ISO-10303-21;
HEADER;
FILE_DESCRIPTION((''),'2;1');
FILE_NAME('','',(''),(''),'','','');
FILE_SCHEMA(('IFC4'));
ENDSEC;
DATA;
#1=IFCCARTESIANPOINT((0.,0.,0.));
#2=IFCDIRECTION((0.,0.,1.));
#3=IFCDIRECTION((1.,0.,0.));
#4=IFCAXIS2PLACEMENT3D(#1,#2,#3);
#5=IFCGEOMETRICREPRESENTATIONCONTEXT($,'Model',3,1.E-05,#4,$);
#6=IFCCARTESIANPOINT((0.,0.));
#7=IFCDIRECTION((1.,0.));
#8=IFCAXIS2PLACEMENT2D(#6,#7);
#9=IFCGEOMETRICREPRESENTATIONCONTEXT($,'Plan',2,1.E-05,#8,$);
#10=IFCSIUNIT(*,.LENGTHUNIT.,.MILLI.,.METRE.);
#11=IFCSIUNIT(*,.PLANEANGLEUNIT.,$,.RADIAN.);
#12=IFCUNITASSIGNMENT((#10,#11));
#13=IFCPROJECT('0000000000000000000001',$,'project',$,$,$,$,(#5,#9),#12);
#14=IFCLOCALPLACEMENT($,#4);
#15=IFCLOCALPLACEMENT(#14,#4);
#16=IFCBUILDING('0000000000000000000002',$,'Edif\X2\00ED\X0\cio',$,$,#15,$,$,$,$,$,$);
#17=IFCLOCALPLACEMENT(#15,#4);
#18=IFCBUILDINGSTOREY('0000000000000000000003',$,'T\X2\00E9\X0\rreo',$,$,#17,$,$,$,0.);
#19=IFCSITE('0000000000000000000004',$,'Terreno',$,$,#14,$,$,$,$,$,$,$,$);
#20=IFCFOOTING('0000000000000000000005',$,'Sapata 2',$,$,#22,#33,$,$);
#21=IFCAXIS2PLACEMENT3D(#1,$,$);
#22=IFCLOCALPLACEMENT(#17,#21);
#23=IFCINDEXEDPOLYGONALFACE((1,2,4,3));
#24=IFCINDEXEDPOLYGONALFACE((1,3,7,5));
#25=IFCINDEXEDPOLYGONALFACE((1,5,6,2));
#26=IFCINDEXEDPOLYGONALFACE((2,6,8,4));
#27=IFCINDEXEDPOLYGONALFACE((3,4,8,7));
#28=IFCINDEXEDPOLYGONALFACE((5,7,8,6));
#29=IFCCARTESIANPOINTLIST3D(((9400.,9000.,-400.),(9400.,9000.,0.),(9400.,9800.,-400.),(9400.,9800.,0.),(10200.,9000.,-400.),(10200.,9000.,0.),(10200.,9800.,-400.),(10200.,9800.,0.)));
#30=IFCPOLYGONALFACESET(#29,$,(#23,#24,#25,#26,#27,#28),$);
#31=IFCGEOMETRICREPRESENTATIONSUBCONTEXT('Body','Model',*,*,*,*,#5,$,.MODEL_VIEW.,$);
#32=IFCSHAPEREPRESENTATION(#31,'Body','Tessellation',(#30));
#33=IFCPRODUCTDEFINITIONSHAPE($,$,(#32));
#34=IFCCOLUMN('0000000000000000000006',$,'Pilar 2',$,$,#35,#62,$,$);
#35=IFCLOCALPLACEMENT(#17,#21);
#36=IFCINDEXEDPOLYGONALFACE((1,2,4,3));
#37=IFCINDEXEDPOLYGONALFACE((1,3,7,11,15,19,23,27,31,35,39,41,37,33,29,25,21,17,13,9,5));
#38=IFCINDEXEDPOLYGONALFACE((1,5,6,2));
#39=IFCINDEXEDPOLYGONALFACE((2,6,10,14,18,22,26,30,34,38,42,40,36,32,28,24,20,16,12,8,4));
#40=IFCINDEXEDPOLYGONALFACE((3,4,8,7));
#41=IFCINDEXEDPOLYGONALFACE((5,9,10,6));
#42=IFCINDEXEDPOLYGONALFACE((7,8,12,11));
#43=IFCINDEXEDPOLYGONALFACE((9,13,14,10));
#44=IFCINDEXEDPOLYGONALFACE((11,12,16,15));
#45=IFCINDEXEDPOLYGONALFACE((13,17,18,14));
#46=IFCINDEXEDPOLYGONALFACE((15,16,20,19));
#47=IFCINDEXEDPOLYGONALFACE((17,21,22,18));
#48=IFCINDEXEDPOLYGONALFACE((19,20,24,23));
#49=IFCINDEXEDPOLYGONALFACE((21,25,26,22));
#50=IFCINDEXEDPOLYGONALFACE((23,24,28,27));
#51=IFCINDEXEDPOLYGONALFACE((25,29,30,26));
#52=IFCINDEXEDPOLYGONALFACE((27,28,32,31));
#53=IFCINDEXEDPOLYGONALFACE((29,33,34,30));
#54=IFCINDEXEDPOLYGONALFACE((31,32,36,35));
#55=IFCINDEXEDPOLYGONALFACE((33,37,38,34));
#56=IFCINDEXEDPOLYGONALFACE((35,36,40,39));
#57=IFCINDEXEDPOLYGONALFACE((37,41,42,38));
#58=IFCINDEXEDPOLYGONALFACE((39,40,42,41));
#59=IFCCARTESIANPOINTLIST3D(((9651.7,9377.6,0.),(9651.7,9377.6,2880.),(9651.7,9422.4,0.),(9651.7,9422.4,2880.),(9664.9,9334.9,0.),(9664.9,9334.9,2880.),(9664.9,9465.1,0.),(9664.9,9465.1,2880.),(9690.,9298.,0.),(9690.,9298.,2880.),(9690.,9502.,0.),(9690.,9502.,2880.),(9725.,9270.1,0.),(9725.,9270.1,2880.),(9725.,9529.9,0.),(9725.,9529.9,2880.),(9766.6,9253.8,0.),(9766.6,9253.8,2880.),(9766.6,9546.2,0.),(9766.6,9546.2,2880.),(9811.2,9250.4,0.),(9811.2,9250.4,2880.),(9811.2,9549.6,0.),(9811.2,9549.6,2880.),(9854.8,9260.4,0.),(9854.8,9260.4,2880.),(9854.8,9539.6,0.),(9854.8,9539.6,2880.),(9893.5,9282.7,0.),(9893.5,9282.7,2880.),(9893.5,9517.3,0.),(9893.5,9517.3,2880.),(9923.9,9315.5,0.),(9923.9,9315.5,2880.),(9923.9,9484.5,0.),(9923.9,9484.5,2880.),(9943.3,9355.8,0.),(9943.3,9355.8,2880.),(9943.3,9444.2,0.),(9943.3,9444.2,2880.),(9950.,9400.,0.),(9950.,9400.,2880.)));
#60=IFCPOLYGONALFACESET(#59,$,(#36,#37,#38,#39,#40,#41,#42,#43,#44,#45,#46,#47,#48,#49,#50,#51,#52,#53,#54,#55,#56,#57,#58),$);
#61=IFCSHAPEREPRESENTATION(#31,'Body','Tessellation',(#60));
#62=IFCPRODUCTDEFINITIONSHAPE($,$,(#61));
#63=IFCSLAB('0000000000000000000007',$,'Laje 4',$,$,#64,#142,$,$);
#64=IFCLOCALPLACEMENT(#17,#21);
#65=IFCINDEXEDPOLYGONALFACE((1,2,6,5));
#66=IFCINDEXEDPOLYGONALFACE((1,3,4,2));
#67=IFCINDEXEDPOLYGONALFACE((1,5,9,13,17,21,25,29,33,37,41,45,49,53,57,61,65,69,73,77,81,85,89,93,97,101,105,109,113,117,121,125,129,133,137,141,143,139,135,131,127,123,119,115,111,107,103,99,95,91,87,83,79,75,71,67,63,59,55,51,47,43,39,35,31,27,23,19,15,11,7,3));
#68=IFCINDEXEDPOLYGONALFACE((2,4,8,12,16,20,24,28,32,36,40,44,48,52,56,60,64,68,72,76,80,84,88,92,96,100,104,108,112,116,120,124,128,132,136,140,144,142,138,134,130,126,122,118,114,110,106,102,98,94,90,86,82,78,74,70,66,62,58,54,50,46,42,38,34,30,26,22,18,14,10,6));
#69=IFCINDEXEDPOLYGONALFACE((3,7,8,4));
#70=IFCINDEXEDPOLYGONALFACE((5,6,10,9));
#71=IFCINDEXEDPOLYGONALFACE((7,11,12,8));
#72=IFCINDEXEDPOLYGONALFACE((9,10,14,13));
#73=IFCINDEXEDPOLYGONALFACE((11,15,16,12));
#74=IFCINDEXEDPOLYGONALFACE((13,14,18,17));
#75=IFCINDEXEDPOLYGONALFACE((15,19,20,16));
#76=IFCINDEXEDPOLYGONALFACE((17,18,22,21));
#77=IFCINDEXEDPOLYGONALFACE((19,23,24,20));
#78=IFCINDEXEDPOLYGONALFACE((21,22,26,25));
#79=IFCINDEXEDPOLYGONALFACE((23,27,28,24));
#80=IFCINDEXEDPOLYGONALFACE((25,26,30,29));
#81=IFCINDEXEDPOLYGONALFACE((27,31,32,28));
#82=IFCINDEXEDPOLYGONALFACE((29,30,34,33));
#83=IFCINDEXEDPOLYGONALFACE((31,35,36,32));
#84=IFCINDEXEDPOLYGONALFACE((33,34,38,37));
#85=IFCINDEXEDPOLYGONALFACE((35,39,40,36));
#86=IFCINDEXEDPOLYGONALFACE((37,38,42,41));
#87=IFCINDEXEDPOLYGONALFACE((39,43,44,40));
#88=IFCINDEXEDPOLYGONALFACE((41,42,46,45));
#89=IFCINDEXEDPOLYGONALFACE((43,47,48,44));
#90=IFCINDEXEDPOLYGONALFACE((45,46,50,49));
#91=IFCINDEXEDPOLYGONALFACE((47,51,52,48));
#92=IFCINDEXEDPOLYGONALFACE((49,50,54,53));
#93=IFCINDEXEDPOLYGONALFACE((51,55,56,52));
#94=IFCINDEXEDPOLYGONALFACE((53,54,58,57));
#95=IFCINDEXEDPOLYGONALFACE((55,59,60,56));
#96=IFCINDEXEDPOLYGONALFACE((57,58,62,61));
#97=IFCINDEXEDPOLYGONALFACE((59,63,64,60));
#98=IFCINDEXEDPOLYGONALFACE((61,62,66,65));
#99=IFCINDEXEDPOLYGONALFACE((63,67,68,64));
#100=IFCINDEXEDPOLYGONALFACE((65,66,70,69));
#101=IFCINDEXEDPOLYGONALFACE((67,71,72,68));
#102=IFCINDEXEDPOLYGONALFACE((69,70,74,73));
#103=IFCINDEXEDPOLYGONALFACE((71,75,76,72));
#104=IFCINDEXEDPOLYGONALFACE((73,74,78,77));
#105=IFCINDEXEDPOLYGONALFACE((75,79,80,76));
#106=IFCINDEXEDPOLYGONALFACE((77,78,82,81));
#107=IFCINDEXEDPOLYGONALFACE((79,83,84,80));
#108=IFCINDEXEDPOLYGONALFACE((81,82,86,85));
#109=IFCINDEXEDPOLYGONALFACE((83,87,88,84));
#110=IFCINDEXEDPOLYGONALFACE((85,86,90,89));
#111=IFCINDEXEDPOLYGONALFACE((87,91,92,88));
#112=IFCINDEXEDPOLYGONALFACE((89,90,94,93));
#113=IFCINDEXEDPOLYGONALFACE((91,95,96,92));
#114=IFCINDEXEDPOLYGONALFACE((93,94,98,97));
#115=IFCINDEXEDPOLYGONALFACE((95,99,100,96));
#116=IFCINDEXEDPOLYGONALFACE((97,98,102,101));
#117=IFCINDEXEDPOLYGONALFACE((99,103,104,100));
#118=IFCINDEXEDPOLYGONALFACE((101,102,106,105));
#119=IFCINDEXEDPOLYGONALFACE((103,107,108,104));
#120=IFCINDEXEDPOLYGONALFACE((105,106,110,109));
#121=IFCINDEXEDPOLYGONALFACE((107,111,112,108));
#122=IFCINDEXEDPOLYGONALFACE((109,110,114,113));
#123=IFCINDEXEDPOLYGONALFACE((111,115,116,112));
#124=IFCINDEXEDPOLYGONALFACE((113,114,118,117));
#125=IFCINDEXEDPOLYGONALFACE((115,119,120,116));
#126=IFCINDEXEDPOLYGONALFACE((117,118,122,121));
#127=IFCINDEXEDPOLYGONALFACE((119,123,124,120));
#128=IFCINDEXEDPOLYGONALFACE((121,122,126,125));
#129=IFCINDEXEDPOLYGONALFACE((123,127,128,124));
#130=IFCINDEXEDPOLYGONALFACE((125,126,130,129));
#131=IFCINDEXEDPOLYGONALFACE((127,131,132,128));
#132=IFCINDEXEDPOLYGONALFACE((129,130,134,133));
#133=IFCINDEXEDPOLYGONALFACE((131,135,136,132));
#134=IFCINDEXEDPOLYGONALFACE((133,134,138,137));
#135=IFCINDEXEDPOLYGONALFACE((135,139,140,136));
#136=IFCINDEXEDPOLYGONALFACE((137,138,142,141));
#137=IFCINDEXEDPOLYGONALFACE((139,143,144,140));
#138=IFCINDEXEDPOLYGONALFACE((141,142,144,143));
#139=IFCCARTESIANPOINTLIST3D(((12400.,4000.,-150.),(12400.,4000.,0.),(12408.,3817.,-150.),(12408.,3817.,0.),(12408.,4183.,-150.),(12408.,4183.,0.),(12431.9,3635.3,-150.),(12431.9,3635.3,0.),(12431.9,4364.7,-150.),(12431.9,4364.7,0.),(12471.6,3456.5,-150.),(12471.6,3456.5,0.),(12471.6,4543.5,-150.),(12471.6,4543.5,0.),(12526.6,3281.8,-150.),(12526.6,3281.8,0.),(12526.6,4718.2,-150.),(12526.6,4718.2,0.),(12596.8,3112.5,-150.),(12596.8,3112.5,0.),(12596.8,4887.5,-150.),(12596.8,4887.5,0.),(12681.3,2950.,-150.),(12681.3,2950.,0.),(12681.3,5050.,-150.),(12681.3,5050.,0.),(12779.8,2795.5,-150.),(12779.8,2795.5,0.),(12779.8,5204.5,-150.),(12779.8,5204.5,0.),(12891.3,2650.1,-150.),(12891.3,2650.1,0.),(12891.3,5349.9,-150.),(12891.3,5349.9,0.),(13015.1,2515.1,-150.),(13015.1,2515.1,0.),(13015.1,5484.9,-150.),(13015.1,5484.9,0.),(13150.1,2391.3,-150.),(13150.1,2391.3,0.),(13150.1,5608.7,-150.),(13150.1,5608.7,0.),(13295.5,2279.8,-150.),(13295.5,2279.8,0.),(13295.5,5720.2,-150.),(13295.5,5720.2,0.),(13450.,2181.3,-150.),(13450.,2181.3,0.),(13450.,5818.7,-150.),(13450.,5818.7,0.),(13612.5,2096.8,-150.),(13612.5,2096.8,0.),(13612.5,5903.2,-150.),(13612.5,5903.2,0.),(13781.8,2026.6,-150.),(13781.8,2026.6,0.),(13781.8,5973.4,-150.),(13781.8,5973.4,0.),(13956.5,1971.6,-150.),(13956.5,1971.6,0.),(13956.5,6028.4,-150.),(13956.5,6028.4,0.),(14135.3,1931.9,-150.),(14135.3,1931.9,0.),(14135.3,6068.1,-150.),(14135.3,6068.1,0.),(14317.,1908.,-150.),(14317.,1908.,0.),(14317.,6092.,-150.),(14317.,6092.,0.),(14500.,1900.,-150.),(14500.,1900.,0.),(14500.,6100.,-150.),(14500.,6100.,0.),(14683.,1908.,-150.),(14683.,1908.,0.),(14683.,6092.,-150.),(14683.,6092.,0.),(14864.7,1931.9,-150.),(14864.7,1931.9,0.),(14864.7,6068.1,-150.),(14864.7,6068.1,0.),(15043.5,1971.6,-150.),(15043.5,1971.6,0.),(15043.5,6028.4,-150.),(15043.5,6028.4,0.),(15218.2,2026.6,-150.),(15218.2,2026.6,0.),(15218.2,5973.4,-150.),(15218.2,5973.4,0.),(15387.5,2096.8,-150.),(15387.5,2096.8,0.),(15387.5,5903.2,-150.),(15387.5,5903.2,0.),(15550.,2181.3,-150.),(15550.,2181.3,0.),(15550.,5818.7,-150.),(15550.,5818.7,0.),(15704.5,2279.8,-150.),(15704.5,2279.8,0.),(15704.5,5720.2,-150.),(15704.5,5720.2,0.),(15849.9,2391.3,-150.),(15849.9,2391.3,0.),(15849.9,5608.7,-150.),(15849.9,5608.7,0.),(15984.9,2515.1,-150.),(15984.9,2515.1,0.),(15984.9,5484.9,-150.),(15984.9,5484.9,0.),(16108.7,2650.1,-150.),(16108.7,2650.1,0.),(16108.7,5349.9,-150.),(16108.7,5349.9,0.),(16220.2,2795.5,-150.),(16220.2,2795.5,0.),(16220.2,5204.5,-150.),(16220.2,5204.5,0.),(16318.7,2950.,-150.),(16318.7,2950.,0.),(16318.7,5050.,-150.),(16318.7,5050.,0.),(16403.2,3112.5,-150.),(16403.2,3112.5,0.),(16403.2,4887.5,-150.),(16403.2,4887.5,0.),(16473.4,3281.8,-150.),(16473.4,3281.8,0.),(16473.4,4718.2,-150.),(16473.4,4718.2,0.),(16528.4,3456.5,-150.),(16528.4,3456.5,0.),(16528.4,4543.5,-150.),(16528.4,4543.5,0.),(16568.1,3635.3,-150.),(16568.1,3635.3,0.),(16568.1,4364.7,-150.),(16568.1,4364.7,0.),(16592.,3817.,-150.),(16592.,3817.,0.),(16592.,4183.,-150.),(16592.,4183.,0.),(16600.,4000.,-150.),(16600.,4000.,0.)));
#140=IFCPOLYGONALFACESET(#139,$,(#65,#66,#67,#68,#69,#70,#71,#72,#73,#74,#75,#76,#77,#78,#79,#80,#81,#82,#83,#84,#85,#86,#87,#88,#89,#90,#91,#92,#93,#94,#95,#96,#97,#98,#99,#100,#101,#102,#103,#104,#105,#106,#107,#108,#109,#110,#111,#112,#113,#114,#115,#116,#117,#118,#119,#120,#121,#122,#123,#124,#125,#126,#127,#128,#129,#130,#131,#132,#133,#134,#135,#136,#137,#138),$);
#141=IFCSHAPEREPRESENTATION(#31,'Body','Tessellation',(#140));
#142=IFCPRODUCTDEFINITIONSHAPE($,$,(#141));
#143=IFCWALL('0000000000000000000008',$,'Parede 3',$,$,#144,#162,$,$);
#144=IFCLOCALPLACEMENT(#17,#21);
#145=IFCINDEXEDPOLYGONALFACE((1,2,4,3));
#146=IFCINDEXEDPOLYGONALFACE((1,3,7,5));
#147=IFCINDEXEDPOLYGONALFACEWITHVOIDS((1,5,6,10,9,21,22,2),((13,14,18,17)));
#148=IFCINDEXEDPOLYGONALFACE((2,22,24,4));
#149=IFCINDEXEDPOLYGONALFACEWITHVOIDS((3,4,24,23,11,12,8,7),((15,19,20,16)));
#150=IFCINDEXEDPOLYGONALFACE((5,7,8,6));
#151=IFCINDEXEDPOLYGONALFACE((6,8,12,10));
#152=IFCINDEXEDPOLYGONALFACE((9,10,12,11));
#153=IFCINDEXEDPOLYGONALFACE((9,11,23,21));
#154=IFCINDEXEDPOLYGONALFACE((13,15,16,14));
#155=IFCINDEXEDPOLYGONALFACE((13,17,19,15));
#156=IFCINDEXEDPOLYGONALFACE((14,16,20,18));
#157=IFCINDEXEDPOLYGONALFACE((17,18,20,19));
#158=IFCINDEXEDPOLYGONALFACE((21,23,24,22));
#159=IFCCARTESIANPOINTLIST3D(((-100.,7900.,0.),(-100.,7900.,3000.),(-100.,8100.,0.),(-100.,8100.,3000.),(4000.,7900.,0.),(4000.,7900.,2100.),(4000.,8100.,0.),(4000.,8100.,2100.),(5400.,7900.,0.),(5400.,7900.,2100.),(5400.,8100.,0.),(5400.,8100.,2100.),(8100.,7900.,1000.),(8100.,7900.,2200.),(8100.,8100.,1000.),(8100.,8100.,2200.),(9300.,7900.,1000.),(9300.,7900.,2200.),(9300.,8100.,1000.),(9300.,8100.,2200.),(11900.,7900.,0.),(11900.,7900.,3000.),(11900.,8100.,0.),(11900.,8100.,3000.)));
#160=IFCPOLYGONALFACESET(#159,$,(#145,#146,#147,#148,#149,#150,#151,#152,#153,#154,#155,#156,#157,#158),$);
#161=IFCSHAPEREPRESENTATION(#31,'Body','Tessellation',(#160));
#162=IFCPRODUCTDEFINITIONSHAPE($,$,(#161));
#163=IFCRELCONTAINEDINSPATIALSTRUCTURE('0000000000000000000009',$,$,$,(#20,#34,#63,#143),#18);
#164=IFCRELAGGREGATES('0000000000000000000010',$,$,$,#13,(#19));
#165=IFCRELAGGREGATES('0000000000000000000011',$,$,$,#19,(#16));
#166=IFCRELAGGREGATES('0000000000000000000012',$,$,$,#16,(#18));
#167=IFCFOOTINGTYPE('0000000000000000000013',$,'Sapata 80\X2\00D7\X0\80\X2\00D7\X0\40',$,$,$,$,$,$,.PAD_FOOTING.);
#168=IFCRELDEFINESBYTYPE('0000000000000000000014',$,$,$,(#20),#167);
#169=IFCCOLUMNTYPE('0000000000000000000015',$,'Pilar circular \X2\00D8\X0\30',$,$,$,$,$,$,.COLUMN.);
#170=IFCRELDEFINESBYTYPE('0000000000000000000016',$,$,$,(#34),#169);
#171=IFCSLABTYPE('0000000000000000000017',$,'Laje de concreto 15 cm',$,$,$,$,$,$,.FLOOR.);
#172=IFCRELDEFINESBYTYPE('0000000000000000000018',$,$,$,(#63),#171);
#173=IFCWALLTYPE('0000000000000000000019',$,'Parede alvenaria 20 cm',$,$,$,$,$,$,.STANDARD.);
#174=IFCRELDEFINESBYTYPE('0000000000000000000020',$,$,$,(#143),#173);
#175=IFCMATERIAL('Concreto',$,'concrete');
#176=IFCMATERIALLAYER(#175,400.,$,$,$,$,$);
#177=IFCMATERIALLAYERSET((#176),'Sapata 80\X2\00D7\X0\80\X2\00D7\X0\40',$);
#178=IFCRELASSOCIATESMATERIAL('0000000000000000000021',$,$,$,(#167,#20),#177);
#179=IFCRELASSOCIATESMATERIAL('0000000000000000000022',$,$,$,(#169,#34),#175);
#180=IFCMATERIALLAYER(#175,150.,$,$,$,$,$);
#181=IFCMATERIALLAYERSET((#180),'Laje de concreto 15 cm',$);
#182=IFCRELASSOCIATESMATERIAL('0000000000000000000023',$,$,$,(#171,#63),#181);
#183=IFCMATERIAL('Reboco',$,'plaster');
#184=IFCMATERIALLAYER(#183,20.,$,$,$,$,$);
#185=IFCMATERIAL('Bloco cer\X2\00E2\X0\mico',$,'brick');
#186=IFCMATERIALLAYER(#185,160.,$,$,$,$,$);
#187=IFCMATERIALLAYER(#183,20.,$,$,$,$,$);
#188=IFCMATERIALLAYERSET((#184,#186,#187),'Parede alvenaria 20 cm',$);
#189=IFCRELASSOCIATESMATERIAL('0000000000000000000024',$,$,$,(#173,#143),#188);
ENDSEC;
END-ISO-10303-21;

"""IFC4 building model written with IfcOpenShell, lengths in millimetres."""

from ifc_helpers import new_model, si_unit, frame, origin_with_axes, origin_2d, origin_2d_with_axis, place, context, subcontext, project, spatial, indexed_curve, circle, outline, extrude, material, layer, layer_set, layer_usage, material_profile, profile_set, profile_usage, type_object, element, save


model = new_model("IFC4")

# Units and contexts
model_context = context("Model", 3, precision=1e-05, world=origin_with_axes())
plan_context = context("Plan", 2, precision=1e-05, world=origin_2d_with_axis())
body_context = subcontext(model_context, "Body", "Model", "MODEL_VIEW")
ifc_project = project(units=[si_unit("LENGTHUNIT", "METRE", prefix="MILLI"), si_unit("PLANEANGLEUNIT", "RADIAN")], contexts=[model_context, plan_context])

# Site, building, storey
site_placement = place(None, origin_with_axes())
site = spatial("IfcSite", under=ifc_project, at=site_placement, Name="Terreno")
building_placement = place(site_placement, origin_with_axes())
building = spatial("IfcBuilding", under=site, at=building_placement, Name="Edifício")
storey_placement = place(building_placement, origin_with_axes())
storey = spatial("IfcBuildingStorey", under=building, at=storey_placement, Name="Térreo", Elevation=0.0)

# Footing
ifc_material_1 = material(Name="Concreto", Category="concrete")
ifc_layer_1 = layer(ifc_material_1, 400.0)
ifc_layer_set_1 = layer_set([ifc_layer_1], Name="Sapata 80×80×40")
ifc_layer_usage_1 = layer_usage(ifc_layer_set_1, "AXIS3", "POSITIVE", 0.0)
footing_type = type_object("IfcFootingType", Name="Sapata 80×80×40", PredefinedType="PAD_FOOTING", material=ifc_layer_set_1)
footing_placement = place(storey_placement, frame((9400.0, 9000.0, -400.0), z_axis=(0.0, 0.0, 1.0), x_axis=(1.0, 0.0, 0.0)))
element("IfcFooting", 1, at=footing_placement, inside=storey, type_object=footing_type, material=ifc_layer_usage_1, Name="Sapata 2", context=body_context, shape_type="SweptSolid", body=[
    extrude(outline(indexed_curve([(0.0, 0.0), (800.0, 0.0), (800.0, 800.0), (0.0, 800.0)])), None, (0.0, 0.0, 1.0), 400.0),
])

# Column
ifc_material_profile_1 = material_profile(ifc_material_1, circle(Radius=150.0))
ifc_profile_set_1 = profile_set([ifc_material_profile_1], Name="Pilar circular Ø30")
ifc_profile_usage_1 = profile_usage(ifc_profile_set_1)
column_type = type_object("IfcColumnType", Name="Pilar circular Ø30", PredefinedType="COLUMN", material=ifc_profile_set_1)
column_placement = place(storey_placement, frame((9800.0, 9400.0, 0.0), z_axis=(0.0, 0.0, 1.0), x_axis=(1.0, 0.0, 0.0)))
element("IfcColumn", 2, at=column_placement, inside=storey, type_object=column_type, material=ifc_profile_usage_1, Name="Pilar 2", context=body_context, shape_type="SweptSolid", body=[
    extrude(circle(Radius=150.0), origin_with_axes(), (0.0, 0.0, 1.0), 2880.0),
])

# Slab
ifc_layer_2 = layer(ifc_material_1, 150.0)
ifc_layer_set_2 = layer_set([ifc_layer_2], Name="Laje de concreto 15 cm")
ifc_layer_usage_2 = layer_usage(ifc_layer_set_2, "AXIS3", "POSITIVE", 0.0)
slab_type = type_object("IfcSlabType", Name="Laje de concreto 15 cm", PredefinedType="FLOOR", material=ifc_layer_set_2)
slab_placement = place(storey_placement, frame((14500.0, 4000.0, -150.0), z_axis=(0.0, 0.0, 1.0), x_axis=(1.0, 0.0, 0.0)))
element("IfcSlab", 3, at=slab_placement, inside=storey, type_object=slab_type, material=ifc_layer_usage_2, Name="Laje 4", context=body_context, shape_type="SweptSolid", body=[
    extrude(circle(Radius=2100.0, at=origin_2d()), origin_with_axes(), (0.0, 0.0, 1.0), 150.0),
])

# Wall, openings
ifc_material_2 = material(Name="Reboco", Category="plaster")
ifc_layer_3 = layer(ifc_material_2, 20.0)
ifc_material_3 = material(Name="Bloco cerâmico", Category="brick")
ifc_layer_4 = layer(ifc_material_3, 160.0)
ifc_layer_5 = layer(ifc_material_2, 20.0)
ifc_layer_set_3 = layer_set([ifc_layer_3, ifc_layer_4, ifc_layer_5], Name="Parede alvenaria 20 cm")
ifc_layer_usage_3 = layer_usage(ifc_layer_set_3, "AXIS2", "POSITIVE", -100.0)
wall_type_1 = type_object("IfcWallType", Name="Parede alvenaria 20 cm", PredefinedType="STANDARD", material=ifc_layer_set_3)
wall_1_placement = place(storey_placement, frame((11900.0, 8000.0, 0.0), z_axis=(0.0, 0.0, 1.0), x_axis=(-1.0, 0.0, 0.0)))
wall_1 = element("IfcWall", 4, at=wall_1_placement, inside=storey, type_object=wall_type_1, material=ifc_layer_usage_3, Name="Parede 3", context=body_context, shape_type="SweptSolid", body=[
    extrude(outline(indexed_curve([(0.0, 0.0), (0.0, 200.0), (12000.0, 200.0), (12000.0, 0.0), (0.0, 0.0)], self_intersect=False)), frame((0.0, -100.0, 0.0), z_axis=(0.0, 0.0, 1.0), x_axis=(1.0, 0.0, 0.0)), (0.0, 0.0, 1.0), 3000.0),
])
opening_1_placement = place(wall_1_placement, frame((6500.0, -110.0, 0.0), z_axis=(0.0, 0.0, 1.0), x_axis=(1.0, 0.0, 0.0)))
element("IfcOpeningElement", 5, at=opening_1_placement, cuts=wall_1, context=body_context, shape_type="SweptSolid", body=[
    extrude(outline(indexed_curve([(0.0, 0.0), (0.0, 220.0), (1400.0, 220.0), (1400.0, 0.0), (0.0, 0.0)], self_intersect=False)), origin_with_axes(), (0.0, 0.0, 1.0), 2100.0),
])
opening_2_placement = place(wall_1_placement, frame((2600.0, -110.0, 1000.0), z_axis=(0.0, 0.0, 1.0), x_axis=(1.0, 0.0, 0.0)))
element("IfcOpeningElement", 6, at=opening_2_placement, cuts=wall_1, context=body_context, shape_type="SweptSolid", body=[
    extrude(outline(indexed_curve([(0.0, 0.0), (0.0, 220.0), (1200.0, 220.0), (1200.0, 0.0), (0.0, 0.0)], self_intersect=False)), origin_with_axes(), (0.0, 0.0, 1.0), 1200.0),
])

save(model, "model.ifc")
